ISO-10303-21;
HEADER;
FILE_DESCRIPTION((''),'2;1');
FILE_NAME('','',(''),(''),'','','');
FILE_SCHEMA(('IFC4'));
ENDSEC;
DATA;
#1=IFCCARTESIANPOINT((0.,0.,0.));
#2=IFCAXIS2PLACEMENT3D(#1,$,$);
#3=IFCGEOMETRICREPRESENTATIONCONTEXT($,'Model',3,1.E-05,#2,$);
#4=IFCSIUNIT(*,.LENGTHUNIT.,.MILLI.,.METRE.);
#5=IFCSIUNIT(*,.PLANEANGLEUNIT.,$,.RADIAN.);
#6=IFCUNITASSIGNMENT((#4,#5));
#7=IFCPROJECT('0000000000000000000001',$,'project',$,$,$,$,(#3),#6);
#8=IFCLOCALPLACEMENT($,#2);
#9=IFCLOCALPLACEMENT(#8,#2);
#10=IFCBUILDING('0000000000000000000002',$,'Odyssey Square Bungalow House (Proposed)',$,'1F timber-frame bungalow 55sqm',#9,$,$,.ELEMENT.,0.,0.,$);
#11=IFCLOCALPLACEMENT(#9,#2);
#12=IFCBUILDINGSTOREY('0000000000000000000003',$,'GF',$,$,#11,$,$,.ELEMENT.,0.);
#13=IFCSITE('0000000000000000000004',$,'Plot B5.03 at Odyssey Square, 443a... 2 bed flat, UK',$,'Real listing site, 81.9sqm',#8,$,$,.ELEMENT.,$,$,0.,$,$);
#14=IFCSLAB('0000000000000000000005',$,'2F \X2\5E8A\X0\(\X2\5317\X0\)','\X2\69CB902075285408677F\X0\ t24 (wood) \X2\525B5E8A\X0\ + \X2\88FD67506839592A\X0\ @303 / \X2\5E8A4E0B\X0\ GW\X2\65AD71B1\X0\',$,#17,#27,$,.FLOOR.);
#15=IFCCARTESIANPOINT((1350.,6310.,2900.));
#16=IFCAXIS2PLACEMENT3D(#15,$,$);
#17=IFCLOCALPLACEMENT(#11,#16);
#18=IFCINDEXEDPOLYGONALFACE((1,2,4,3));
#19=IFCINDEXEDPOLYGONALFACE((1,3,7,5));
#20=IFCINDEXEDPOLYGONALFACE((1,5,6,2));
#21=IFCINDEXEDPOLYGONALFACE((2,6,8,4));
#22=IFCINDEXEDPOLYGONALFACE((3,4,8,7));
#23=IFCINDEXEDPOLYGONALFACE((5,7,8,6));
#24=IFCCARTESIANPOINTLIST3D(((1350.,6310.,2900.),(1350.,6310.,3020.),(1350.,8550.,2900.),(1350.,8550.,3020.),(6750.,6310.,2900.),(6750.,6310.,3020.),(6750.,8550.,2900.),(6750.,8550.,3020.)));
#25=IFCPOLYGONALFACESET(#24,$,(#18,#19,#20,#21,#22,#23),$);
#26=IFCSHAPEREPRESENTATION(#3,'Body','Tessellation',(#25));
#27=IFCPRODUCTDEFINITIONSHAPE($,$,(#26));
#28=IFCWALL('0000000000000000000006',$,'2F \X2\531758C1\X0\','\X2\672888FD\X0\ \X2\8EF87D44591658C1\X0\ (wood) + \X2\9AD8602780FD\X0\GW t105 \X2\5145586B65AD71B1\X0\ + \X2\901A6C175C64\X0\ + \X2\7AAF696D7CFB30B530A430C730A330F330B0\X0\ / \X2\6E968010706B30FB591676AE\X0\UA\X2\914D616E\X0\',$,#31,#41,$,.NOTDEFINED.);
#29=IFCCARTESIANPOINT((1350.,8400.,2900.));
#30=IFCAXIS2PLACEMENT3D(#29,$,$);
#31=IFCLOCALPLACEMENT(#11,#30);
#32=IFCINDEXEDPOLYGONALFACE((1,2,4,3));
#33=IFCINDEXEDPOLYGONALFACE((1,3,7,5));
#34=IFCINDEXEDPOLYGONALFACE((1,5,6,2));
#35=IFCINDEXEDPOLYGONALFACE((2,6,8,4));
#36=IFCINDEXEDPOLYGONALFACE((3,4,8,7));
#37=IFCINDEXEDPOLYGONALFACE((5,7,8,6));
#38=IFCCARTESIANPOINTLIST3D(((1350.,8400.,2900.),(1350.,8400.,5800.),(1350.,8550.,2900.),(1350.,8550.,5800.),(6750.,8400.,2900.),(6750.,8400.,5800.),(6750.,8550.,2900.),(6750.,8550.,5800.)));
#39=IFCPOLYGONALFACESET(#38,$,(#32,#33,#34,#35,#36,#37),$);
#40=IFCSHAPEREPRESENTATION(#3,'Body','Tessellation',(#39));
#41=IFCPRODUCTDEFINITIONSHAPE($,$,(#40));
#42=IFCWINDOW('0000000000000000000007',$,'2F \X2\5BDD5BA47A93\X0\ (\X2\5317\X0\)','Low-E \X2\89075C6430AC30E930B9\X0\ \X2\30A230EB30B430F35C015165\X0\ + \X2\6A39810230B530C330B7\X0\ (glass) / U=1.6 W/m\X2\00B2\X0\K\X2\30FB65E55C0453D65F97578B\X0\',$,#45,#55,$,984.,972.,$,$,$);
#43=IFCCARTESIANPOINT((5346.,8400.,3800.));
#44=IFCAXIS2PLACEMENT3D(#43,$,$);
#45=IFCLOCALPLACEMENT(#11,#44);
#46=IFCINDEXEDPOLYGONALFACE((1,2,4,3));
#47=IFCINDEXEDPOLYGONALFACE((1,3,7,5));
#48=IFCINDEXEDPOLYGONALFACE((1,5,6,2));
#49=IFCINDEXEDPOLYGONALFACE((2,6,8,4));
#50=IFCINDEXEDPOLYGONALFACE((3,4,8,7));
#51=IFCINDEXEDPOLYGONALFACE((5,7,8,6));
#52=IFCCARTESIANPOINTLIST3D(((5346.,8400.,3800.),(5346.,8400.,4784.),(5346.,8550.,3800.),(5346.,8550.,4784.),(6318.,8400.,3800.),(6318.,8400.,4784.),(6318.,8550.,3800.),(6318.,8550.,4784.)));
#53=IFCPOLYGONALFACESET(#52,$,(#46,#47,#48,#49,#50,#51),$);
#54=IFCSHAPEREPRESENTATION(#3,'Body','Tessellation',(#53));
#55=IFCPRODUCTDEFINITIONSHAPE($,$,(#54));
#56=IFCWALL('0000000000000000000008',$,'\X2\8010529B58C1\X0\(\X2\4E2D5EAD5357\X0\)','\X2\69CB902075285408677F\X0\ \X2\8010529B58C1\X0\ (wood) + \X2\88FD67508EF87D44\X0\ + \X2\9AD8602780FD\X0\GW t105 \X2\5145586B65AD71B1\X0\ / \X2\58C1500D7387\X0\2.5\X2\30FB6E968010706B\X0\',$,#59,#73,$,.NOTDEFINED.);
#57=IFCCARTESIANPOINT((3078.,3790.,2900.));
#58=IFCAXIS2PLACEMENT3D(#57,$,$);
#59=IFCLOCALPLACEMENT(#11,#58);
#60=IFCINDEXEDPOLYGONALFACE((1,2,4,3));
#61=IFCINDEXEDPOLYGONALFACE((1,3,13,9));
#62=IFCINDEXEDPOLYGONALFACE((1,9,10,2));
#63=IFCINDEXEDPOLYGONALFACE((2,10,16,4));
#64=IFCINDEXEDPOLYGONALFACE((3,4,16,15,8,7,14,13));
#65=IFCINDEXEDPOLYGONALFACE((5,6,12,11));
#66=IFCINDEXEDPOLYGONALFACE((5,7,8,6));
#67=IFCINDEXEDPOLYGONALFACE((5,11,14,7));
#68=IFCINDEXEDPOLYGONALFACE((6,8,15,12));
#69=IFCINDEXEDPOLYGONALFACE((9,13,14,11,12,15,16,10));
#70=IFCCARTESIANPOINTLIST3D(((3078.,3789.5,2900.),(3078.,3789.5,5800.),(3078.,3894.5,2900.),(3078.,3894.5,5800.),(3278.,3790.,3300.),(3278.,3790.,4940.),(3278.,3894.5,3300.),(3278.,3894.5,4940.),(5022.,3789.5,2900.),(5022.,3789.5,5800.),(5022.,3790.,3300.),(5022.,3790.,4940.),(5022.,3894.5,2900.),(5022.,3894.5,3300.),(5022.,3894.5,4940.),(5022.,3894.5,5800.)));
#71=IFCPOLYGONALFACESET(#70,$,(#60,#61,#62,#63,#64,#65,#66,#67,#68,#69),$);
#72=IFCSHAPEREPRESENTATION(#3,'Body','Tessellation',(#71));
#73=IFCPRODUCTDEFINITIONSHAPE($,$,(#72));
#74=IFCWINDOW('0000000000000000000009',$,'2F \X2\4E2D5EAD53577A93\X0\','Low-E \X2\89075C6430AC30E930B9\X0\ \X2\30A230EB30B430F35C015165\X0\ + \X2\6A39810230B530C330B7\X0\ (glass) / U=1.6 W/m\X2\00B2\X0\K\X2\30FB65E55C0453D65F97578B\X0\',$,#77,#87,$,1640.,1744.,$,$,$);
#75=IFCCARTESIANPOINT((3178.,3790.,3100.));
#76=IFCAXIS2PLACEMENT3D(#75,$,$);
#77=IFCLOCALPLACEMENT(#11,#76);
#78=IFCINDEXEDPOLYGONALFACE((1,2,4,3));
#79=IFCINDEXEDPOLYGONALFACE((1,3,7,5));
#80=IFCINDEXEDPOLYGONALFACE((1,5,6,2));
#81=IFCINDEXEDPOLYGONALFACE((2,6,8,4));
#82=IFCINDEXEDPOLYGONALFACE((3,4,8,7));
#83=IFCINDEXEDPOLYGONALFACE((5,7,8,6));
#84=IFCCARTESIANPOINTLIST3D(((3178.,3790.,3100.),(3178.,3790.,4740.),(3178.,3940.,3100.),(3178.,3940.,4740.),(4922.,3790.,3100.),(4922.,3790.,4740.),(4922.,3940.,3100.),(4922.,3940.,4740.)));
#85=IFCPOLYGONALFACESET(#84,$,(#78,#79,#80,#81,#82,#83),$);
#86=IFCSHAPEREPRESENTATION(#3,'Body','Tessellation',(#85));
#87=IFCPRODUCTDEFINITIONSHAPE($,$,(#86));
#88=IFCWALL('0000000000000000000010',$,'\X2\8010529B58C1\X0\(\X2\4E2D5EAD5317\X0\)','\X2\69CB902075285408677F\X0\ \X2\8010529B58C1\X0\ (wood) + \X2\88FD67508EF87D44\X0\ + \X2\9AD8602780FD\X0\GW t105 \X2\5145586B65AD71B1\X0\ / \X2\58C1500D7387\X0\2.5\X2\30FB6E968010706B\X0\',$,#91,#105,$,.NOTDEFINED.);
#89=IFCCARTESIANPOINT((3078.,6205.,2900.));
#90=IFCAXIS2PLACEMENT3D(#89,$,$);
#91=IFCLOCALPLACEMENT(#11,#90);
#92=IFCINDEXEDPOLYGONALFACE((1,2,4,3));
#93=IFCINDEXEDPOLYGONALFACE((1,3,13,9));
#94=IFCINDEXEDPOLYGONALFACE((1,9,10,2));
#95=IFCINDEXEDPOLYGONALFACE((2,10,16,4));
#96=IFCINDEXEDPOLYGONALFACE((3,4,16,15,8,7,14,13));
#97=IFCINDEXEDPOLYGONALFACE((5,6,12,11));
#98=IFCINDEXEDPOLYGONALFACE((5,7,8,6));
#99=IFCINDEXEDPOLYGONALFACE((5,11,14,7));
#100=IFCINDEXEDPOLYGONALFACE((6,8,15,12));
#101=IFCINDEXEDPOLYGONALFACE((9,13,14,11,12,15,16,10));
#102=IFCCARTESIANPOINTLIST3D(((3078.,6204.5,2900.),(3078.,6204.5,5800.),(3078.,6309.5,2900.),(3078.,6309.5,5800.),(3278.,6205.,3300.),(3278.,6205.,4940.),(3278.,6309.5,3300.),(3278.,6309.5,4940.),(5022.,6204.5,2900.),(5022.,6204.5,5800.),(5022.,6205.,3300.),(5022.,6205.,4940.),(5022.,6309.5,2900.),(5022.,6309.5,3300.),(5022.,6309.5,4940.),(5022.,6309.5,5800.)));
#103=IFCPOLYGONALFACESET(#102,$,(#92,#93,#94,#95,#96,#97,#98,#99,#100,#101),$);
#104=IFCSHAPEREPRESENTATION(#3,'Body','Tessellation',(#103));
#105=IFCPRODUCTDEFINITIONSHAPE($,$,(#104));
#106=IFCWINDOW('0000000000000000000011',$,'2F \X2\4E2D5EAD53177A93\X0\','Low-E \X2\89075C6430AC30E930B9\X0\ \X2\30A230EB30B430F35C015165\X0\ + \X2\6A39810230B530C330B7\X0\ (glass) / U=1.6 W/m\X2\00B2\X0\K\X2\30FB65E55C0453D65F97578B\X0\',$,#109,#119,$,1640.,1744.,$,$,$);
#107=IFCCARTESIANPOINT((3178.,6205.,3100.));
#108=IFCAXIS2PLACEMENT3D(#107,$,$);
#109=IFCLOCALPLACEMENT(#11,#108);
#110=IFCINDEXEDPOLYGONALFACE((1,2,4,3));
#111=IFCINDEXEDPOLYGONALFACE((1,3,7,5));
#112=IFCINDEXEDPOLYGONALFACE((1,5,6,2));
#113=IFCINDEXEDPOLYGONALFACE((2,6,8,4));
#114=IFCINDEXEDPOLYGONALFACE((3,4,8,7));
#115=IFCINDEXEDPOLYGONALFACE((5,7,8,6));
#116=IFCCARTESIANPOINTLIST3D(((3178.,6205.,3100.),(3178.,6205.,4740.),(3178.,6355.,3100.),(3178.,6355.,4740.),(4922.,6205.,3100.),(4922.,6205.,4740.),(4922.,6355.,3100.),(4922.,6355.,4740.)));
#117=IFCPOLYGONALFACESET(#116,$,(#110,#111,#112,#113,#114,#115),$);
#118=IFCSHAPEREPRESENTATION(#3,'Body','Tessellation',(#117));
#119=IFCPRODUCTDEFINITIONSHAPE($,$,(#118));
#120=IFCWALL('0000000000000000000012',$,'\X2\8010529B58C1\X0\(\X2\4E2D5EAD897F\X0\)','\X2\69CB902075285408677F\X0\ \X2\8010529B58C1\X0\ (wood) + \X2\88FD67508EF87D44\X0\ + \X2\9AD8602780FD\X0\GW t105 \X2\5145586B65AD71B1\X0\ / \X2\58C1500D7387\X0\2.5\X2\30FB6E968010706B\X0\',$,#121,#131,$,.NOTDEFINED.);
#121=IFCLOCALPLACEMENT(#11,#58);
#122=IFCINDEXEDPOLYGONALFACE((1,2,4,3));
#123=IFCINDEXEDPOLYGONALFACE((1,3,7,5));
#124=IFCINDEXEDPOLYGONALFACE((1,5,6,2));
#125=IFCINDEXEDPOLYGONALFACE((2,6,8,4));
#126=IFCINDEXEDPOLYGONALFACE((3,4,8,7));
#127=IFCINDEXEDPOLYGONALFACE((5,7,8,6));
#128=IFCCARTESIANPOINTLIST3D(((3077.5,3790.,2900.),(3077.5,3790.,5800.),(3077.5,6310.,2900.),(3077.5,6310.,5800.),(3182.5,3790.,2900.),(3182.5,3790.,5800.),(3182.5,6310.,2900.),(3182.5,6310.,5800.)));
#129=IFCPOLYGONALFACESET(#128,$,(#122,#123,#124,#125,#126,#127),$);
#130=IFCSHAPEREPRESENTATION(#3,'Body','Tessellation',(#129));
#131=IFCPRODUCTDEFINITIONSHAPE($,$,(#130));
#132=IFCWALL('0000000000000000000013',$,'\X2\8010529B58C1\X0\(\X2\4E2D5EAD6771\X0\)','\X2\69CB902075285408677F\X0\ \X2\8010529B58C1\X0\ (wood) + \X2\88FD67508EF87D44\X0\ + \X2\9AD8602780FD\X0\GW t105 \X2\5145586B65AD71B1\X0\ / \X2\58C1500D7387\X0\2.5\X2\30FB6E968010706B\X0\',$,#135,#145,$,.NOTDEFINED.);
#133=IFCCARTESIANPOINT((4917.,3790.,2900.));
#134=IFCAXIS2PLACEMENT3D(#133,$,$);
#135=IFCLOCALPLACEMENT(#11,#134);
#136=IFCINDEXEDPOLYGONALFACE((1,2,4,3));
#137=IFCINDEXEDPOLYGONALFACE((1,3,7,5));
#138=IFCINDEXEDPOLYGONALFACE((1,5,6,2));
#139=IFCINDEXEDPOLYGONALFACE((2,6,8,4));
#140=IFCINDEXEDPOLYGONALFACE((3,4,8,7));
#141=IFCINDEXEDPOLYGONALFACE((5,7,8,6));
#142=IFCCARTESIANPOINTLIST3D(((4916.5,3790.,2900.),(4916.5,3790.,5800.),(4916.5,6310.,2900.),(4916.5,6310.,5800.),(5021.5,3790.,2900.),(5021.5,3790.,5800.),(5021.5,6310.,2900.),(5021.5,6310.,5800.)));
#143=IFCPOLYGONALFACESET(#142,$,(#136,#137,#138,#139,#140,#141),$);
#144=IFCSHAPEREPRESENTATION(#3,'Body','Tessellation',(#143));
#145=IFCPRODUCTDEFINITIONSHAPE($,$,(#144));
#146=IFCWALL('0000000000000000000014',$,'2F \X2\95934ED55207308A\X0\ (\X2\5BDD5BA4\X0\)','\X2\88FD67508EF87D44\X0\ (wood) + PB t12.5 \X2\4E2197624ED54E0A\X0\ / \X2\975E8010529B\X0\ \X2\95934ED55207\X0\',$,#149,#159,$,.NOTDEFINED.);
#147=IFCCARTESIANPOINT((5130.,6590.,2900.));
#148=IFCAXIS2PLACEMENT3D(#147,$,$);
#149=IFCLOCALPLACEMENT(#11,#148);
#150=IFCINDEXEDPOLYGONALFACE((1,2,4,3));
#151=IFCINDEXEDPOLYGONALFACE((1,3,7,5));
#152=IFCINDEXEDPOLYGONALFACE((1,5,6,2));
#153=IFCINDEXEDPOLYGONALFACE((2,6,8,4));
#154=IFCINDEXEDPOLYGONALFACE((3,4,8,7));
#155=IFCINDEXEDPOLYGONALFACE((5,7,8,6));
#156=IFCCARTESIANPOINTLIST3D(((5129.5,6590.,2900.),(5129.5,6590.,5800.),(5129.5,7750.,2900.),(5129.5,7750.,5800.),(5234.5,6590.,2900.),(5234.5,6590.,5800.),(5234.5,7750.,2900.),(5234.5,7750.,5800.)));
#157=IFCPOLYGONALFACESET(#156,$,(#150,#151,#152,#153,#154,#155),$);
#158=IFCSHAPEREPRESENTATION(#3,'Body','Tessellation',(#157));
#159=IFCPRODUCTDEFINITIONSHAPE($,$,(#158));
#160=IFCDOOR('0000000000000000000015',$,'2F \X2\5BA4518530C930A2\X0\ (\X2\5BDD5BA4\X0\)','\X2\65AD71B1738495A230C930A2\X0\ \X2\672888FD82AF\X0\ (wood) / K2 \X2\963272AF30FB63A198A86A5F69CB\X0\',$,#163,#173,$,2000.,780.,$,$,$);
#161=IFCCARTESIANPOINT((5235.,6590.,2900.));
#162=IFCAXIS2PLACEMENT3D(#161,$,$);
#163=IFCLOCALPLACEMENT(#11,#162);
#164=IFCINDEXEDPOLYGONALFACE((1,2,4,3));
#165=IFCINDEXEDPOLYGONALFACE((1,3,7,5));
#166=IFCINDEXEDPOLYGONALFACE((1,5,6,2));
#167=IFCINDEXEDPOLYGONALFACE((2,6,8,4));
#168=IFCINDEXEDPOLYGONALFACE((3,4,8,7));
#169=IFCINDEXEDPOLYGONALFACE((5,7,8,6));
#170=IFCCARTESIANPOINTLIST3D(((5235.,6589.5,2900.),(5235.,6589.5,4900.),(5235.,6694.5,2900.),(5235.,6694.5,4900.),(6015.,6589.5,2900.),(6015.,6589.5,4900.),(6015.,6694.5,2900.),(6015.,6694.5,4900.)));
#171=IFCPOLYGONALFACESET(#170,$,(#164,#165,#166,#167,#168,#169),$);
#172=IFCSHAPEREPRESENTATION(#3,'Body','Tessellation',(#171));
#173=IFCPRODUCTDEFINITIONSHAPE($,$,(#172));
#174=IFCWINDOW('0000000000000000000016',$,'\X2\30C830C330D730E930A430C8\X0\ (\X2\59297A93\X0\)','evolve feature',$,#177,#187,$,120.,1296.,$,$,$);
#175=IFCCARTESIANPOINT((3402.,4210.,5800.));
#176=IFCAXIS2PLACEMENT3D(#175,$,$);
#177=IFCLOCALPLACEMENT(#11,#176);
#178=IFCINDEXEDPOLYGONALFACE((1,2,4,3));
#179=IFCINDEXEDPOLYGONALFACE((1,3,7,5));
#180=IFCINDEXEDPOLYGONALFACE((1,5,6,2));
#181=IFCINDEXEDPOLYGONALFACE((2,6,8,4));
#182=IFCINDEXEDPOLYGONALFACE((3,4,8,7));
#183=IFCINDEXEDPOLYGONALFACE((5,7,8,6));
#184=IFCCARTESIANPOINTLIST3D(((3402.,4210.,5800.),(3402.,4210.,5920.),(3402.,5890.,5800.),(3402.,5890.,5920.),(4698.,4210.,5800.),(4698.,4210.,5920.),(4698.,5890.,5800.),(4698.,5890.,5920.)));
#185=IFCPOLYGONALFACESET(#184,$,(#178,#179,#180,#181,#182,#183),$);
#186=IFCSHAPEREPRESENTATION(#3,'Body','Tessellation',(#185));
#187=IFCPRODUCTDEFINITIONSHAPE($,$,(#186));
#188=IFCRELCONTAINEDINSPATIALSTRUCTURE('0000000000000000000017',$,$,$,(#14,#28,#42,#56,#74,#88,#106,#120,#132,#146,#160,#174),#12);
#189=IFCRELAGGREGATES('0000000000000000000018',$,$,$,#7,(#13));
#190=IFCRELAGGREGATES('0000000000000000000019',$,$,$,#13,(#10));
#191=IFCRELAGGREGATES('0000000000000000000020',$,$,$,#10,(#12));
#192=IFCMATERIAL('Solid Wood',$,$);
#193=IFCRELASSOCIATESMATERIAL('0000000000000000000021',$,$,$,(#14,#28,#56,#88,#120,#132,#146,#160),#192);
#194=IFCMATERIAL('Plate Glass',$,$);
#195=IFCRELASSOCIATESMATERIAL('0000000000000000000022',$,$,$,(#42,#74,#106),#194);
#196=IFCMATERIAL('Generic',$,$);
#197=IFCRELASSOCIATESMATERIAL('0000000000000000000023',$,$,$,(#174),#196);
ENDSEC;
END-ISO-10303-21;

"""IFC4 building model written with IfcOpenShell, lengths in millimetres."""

from ifc_helpers import new_model, si_unit, frame, frame_2d, origin, place, context, project, spatial, rectangle, extrude, material, element, fill, save


model = new_model("IFC4")

# Units and contexts
model_context = context("Model", 3, precision=1e-05, world=origin())
ifc_project = project(units=[si_unit("LENGTHUNIT", "METRE", prefix="MILLI"), si_unit("PLANEANGLEUNIT", "RADIAN")], contexts=[model_context])

# Site, building, storey
site_placement = place(None, origin())
site = spatial("IfcSite", under=ifc_project, at=site_placement, Name="Plot B5.03 at Odyssey Square, 443a... 2 bed flat, UK", ObjectType="Real listing site, 81.9sqm", CompositionType="ELEMENT", RefElevation=0.0)
building_placement = place(site_placement, origin())
building = spatial("IfcBuilding", under=site, at=building_placement, Name="Odyssey Square Bungalow House (Proposed)", ObjectType="1F timber-frame bungalow 55sqm", CompositionType="ELEMENT", ElevationOfRefHeight=0.0, ElevationOfTerrain=0.0)
storey_placement = place(building_placement, origin())
storey = spatial("IfcBuildingStorey", under=building, at=storey_placement, Name="GF", CompositionType="ELEMENT", Elevation=0.0)

# Slab
ifc_material_1 = material(Name="Solid Wood")
slab_placement = place(storey_placement, frame((1350.0, 6310.0, 2900.0)))
element("IfcSlab", 1, at=slab_placement, inside=storey, material=ifc_material_1, Name="2F 床(北)", Description="構造用合板 t24 (wood) 剛床 + 製材根太 @303 / 床下 GW断熱", PredefinedType="FLOOR", context=model_context, shape_type="SweptSolid", body=[
    extrude(rectangle(XDim=5400.0, YDim=2240.0, at=frame_2d((2700.0, 1120.0))), frame((1350.0, 6310.0, 2900.0)), (0.0, 0.0, 1.0), 120.0),
])

# Walls, openings, windows
wall_1_placement = place(storey_placement, frame((1350.0, 8400.0, 2900.0)))
wall_1 = element("IfcWall", 2, at=wall_1_placement, inside=storey, material=ifc_material_1, Name="2F 北壁", Description="木製 軸組外壁 (wood) + 高性能GW t105 充填断熱 + 通気層 + 窯業系サイディング / 準耐火・外皮UA配慮", PredefinedType="NOTDEFINED", context=model_context, shape_type="SweptSolid", body=[
    extrude(rectangle(XDim=5400.0, YDim=150.0, at=frame_2d((2700.0, 75.0))), frame((1350.0, 8400.0, 2900.0)), (0.0, 0.0, 1.0), 2900.0),
])
opening_1_placement = place(storey_placement, frame((5346.0, 8400.0, 3800.0)))
opening_1 = element("IfcOpeningElement", 3, at=opening_1_placement, cuts=wall_1, PredefinedType="NOTDEFINED", context=model_context, shape_type="SweptSolid", body=[
    extrude(rectangle(XDim=972.0, YDim=150.0, at=frame_2d((486.0, 75.0))), frame((5346.0, 8400.0, 3800.0)), (0.0, 0.0, 1.0), 984.0),
])
ifc_material_2 = material(Name="Plate Glass")
window_1_placement = place(storey_placement, frame((5346.0, 8400.0, 3800.0)))
window_1 = element("IfcWindow", 4, at=window_1_placement, inside=storey, material=ifc_material_2, Name="2F 寝室窓 (北)", Description="Low-E 複層ガラス アルゴン封入 + 樹脂サッシ (glass) / U=1.6 W/m²K・日射取得型", OverallHeight=984.0, OverallWidth=972.0, context=model_context, shape_type="SweptSolid", body=[
    extrude(rectangle(XDim=972.0, YDim=150.0, at=frame_2d((486.0, 75.0))), frame((5346.0, 8400.0, 3800.0)), (0.0, 0.0, 1.0), 984.0),
])
fill(opening_1, window_1)
wall_2_placement = place(storey_placement, frame((3078.0, 3790.0, 2900.0)))
wall_2 = element("IfcWall", 5, at=wall_2_placement, inside=storey, material=ifc_material_1, Name="耐力壁(中庭南)", Description="構造用合板 耐力壁 (wood) + 製材軸組 + 高性能GW t105 充填断熱 / 壁倍率2.5・準耐火", PredefinedType="NOTDEFINED", context=model_context, shape_type="SweptSolid", body=[
    extrude(rectangle(XDim=1944.0, YDim=105.0, at=frame_2d((972.0, 52.0))), frame((3078.0, 3790.0, 2900.0)), (0.0, 0.0, 1.0), 2900.0),
])
opening_2_placement = place(storey_placement, frame((3178.0, 3790.0, 3100.0)))
opening_2 = element("IfcOpeningElement", 6, at=opening_2_placement, cuts=wall_2, PredefinedType="NOTDEFINED", context=model_context, shape_type="SweptSolid", body=[
    extrude(rectangle(XDim=1744.0, YDim=150.0, at=frame_2d((872.0, 75.0))), frame((3178.0, 3790.0, 3100.0)), (0.0, 0.0, 1.0), 1640.0),
])
window_2_placement = place(storey_placement, frame((3178.0, 3790.0, 3100.0)))
window_2 = element("IfcWindow", 7, at=window_2_placement, inside=storey, material=ifc_material_2, Name="2F 中庭南窓", Description="Low-E 複層ガラス アルゴン封入 + 樹脂サッシ (glass) / U=1.6 W/m²K・日射取得型", OverallHeight=1640.0, OverallWidth=1744.0, context=model_context, shape_type="SweptSolid", body=[
    extrude(rectangle(XDim=1744.0, YDim=150.0, at=frame_2d((872.0, 75.0))), frame((3178.0, 3790.0, 3100.0)), (0.0, 0.0, 1.0), 1640.0),
])
fill(opening_2, window_2)
wall_3_placement = place(storey_placement, frame((3078.0, 6205.0, 2900.0)))
wall_3 = element("IfcWall", 8, at=wall_3_placement, inside=storey, material=ifc_material_1, Name="耐力壁(中庭北)", Description="構造用合板 耐力壁 (wood) + 製材軸組 + 高性能GW t105 充填断熱 / 壁倍率2.5・準耐火", PredefinedType="NOTDEFINED", context=model_context, shape_type="SweptSolid", body=[
    extrude(rectangle(XDim=1944.0, YDim=105.0, at=frame_2d((972.0, 52.0))), frame((3078.0, 6205.0, 2900.0)), (0.0, 0.0, 1.0), 2900.0),
])
opening_3_placement = place(storey_placement, frame((3178.0, 6205.0, 3100.0)))
opening_3 = element("IfcOpeningElement", 9, at=opening_3_placement, cuts=wall_3, PredefinedType="NOTDEFINED", context=model_context, shape_type="SweptSolid", body=[
    extrude(rectangle(XDim=1744.0, YDim=150.0, at=frame_2d((872.0, 75.0))), frame((3178.0, 6205.0, 3100.0)), (0.0, 0.0, 1.0), 1640.0),
])
window_3_placement = place(storey_placement, frame((3178.0, 6205.0, 3100.0)))
window_3 = element("IfcWindow", 10, at=window_3_placement, inside=storey, material=ifc_material_2, Name="2F 中庭北窓", Description="Low-E 複層ガラス アルゴン封入 + 樹脂サッシ (glass) / U=1.6 W/m²K・日射取得型", OverallHeight=1640.0, OverallWidth=1744.0, context=model_context, shape_type="SweptSolid", body=[
    extrude(rectangle(XDim=1744.0, YDim=150.0, at=frame_2d((872.0, 75.0))), frame((3178.0, 6205.0, 3100.0)), (0.0, 0.0, 1.0), 1640.0),
])
fill(opening_3, window_3)

# Walls
wall_4_placement = place(storey_placement, frame((3078.0, 3790.0, 2900.0)))
element("IfcWall", 11, at=wall_4_placement, inside=storey, material=ifc_material_1, Name="耐力壁(中庭西)", Description="構造用合板 耐力壁 (wood) + 製材軸組 + 高性能GW t105 充填断熱 / 壁倍率2.5・準耐火", PredefinedType="NOTDEFINED", context=model_context, shape_type="SweptSolid", body=[
    extrude(rectangle(XDim=105.0, YDim=2520.0, at=frame_2d((52.0, 1260.0))), frame((3078.0, 3790.0, 2900.0)), (0.0, 0.0, 1.0), 2900.0),
])
wall_5_placement = place(storey_placement, frame((4917.0, 3790.0, 2900.0)))
element("IfcWall", 12, at=wall_5_placement, inside=storey, material=ifc_material_1, Name="耐力壁(中庭東)", Description="構造用合板 耐力壁 (wood) + 製材軸組 + 高性能GW t105 充填断熱 / 壁倍率2.5・準耐火", PredefinedType="NOTDEFINED", context=model_context, shape_type="SweptSolid", body=[
    extrude(rectangle(XDim=105.0, YDim=2520.0, at=frame_2d((52.0, 1260.0))), frame((4917.0, 3790.0, 2900.0)), (0.0, 0.0, 1.0), 2900.0),
])
wall_6_placement = place(storey_placement, frame((5130.0, 6590.0, 2900.0)))
element("IfcWall", 13, at=wall_6_placement, inside=storey, material=ifc_material_1, Name="2F 間仕切り (寝室)", Description="製材軸組 (wood) + PB t12.5 両面仕上 / 非耐力 間仕切", PredefinedType="NOTDEFINED", context=model_context, shape_type="SweptSolid", body=[
    extrude(rectangle(XDim=105.0, YDim=1160.0, at=frame_2d((52.0, 580.0))), frame((5130.0, 6590.0, 2900.0)), (0.0, 0.0, 1.0), 2900.0),
])

# Door
door_placement = place(storey_placement, frame((5235.0, 6590.0, 2900.0)))
element("IfcDoor", 14, at=door_placement, inside=storey, material=ifc_material_1, Name="2F 室内ドア (寝室)", Description="断熱玄関ドア 木製芯 (wood) / K2 防犯・採風機構", OverallHeight=2000.0, OverallWidth=780.0, context=model_context, shape_type="SweptSolid", body=[
    extrude(rectangle(XDim=780.0, YDim=105.0, at=frame_2d((390.0, 52.0))), frame((5235.0, 6590.0, 2900.0)), (0.0, 0.0, 1.0), 2000.0),
])

# Window
ifc_material_3 = material(Name="Generic")
window_4_placement = place(storey_placement, frame((3402.0, 4210.0, 5800.0)))
element("IfcWindow", 15, at=window_4_placement, inside=storey, material=ifc_material_3, Name="トップライト (天窓)", Description="evolve feature", OverallHeight=120.0, OverallWidth=1296.0, context=model_context, shape_type="SweptSolid", body=[
    extrude(rectangle(XDim=1296.0, YDim=1680.0, at=frame_2d((648.0, 840.0))), frame((3402.0, 4210.0, 5800.0)), (0.0, 0.0, 1.0), 120.0),
])

save(model, "model.ifc")
